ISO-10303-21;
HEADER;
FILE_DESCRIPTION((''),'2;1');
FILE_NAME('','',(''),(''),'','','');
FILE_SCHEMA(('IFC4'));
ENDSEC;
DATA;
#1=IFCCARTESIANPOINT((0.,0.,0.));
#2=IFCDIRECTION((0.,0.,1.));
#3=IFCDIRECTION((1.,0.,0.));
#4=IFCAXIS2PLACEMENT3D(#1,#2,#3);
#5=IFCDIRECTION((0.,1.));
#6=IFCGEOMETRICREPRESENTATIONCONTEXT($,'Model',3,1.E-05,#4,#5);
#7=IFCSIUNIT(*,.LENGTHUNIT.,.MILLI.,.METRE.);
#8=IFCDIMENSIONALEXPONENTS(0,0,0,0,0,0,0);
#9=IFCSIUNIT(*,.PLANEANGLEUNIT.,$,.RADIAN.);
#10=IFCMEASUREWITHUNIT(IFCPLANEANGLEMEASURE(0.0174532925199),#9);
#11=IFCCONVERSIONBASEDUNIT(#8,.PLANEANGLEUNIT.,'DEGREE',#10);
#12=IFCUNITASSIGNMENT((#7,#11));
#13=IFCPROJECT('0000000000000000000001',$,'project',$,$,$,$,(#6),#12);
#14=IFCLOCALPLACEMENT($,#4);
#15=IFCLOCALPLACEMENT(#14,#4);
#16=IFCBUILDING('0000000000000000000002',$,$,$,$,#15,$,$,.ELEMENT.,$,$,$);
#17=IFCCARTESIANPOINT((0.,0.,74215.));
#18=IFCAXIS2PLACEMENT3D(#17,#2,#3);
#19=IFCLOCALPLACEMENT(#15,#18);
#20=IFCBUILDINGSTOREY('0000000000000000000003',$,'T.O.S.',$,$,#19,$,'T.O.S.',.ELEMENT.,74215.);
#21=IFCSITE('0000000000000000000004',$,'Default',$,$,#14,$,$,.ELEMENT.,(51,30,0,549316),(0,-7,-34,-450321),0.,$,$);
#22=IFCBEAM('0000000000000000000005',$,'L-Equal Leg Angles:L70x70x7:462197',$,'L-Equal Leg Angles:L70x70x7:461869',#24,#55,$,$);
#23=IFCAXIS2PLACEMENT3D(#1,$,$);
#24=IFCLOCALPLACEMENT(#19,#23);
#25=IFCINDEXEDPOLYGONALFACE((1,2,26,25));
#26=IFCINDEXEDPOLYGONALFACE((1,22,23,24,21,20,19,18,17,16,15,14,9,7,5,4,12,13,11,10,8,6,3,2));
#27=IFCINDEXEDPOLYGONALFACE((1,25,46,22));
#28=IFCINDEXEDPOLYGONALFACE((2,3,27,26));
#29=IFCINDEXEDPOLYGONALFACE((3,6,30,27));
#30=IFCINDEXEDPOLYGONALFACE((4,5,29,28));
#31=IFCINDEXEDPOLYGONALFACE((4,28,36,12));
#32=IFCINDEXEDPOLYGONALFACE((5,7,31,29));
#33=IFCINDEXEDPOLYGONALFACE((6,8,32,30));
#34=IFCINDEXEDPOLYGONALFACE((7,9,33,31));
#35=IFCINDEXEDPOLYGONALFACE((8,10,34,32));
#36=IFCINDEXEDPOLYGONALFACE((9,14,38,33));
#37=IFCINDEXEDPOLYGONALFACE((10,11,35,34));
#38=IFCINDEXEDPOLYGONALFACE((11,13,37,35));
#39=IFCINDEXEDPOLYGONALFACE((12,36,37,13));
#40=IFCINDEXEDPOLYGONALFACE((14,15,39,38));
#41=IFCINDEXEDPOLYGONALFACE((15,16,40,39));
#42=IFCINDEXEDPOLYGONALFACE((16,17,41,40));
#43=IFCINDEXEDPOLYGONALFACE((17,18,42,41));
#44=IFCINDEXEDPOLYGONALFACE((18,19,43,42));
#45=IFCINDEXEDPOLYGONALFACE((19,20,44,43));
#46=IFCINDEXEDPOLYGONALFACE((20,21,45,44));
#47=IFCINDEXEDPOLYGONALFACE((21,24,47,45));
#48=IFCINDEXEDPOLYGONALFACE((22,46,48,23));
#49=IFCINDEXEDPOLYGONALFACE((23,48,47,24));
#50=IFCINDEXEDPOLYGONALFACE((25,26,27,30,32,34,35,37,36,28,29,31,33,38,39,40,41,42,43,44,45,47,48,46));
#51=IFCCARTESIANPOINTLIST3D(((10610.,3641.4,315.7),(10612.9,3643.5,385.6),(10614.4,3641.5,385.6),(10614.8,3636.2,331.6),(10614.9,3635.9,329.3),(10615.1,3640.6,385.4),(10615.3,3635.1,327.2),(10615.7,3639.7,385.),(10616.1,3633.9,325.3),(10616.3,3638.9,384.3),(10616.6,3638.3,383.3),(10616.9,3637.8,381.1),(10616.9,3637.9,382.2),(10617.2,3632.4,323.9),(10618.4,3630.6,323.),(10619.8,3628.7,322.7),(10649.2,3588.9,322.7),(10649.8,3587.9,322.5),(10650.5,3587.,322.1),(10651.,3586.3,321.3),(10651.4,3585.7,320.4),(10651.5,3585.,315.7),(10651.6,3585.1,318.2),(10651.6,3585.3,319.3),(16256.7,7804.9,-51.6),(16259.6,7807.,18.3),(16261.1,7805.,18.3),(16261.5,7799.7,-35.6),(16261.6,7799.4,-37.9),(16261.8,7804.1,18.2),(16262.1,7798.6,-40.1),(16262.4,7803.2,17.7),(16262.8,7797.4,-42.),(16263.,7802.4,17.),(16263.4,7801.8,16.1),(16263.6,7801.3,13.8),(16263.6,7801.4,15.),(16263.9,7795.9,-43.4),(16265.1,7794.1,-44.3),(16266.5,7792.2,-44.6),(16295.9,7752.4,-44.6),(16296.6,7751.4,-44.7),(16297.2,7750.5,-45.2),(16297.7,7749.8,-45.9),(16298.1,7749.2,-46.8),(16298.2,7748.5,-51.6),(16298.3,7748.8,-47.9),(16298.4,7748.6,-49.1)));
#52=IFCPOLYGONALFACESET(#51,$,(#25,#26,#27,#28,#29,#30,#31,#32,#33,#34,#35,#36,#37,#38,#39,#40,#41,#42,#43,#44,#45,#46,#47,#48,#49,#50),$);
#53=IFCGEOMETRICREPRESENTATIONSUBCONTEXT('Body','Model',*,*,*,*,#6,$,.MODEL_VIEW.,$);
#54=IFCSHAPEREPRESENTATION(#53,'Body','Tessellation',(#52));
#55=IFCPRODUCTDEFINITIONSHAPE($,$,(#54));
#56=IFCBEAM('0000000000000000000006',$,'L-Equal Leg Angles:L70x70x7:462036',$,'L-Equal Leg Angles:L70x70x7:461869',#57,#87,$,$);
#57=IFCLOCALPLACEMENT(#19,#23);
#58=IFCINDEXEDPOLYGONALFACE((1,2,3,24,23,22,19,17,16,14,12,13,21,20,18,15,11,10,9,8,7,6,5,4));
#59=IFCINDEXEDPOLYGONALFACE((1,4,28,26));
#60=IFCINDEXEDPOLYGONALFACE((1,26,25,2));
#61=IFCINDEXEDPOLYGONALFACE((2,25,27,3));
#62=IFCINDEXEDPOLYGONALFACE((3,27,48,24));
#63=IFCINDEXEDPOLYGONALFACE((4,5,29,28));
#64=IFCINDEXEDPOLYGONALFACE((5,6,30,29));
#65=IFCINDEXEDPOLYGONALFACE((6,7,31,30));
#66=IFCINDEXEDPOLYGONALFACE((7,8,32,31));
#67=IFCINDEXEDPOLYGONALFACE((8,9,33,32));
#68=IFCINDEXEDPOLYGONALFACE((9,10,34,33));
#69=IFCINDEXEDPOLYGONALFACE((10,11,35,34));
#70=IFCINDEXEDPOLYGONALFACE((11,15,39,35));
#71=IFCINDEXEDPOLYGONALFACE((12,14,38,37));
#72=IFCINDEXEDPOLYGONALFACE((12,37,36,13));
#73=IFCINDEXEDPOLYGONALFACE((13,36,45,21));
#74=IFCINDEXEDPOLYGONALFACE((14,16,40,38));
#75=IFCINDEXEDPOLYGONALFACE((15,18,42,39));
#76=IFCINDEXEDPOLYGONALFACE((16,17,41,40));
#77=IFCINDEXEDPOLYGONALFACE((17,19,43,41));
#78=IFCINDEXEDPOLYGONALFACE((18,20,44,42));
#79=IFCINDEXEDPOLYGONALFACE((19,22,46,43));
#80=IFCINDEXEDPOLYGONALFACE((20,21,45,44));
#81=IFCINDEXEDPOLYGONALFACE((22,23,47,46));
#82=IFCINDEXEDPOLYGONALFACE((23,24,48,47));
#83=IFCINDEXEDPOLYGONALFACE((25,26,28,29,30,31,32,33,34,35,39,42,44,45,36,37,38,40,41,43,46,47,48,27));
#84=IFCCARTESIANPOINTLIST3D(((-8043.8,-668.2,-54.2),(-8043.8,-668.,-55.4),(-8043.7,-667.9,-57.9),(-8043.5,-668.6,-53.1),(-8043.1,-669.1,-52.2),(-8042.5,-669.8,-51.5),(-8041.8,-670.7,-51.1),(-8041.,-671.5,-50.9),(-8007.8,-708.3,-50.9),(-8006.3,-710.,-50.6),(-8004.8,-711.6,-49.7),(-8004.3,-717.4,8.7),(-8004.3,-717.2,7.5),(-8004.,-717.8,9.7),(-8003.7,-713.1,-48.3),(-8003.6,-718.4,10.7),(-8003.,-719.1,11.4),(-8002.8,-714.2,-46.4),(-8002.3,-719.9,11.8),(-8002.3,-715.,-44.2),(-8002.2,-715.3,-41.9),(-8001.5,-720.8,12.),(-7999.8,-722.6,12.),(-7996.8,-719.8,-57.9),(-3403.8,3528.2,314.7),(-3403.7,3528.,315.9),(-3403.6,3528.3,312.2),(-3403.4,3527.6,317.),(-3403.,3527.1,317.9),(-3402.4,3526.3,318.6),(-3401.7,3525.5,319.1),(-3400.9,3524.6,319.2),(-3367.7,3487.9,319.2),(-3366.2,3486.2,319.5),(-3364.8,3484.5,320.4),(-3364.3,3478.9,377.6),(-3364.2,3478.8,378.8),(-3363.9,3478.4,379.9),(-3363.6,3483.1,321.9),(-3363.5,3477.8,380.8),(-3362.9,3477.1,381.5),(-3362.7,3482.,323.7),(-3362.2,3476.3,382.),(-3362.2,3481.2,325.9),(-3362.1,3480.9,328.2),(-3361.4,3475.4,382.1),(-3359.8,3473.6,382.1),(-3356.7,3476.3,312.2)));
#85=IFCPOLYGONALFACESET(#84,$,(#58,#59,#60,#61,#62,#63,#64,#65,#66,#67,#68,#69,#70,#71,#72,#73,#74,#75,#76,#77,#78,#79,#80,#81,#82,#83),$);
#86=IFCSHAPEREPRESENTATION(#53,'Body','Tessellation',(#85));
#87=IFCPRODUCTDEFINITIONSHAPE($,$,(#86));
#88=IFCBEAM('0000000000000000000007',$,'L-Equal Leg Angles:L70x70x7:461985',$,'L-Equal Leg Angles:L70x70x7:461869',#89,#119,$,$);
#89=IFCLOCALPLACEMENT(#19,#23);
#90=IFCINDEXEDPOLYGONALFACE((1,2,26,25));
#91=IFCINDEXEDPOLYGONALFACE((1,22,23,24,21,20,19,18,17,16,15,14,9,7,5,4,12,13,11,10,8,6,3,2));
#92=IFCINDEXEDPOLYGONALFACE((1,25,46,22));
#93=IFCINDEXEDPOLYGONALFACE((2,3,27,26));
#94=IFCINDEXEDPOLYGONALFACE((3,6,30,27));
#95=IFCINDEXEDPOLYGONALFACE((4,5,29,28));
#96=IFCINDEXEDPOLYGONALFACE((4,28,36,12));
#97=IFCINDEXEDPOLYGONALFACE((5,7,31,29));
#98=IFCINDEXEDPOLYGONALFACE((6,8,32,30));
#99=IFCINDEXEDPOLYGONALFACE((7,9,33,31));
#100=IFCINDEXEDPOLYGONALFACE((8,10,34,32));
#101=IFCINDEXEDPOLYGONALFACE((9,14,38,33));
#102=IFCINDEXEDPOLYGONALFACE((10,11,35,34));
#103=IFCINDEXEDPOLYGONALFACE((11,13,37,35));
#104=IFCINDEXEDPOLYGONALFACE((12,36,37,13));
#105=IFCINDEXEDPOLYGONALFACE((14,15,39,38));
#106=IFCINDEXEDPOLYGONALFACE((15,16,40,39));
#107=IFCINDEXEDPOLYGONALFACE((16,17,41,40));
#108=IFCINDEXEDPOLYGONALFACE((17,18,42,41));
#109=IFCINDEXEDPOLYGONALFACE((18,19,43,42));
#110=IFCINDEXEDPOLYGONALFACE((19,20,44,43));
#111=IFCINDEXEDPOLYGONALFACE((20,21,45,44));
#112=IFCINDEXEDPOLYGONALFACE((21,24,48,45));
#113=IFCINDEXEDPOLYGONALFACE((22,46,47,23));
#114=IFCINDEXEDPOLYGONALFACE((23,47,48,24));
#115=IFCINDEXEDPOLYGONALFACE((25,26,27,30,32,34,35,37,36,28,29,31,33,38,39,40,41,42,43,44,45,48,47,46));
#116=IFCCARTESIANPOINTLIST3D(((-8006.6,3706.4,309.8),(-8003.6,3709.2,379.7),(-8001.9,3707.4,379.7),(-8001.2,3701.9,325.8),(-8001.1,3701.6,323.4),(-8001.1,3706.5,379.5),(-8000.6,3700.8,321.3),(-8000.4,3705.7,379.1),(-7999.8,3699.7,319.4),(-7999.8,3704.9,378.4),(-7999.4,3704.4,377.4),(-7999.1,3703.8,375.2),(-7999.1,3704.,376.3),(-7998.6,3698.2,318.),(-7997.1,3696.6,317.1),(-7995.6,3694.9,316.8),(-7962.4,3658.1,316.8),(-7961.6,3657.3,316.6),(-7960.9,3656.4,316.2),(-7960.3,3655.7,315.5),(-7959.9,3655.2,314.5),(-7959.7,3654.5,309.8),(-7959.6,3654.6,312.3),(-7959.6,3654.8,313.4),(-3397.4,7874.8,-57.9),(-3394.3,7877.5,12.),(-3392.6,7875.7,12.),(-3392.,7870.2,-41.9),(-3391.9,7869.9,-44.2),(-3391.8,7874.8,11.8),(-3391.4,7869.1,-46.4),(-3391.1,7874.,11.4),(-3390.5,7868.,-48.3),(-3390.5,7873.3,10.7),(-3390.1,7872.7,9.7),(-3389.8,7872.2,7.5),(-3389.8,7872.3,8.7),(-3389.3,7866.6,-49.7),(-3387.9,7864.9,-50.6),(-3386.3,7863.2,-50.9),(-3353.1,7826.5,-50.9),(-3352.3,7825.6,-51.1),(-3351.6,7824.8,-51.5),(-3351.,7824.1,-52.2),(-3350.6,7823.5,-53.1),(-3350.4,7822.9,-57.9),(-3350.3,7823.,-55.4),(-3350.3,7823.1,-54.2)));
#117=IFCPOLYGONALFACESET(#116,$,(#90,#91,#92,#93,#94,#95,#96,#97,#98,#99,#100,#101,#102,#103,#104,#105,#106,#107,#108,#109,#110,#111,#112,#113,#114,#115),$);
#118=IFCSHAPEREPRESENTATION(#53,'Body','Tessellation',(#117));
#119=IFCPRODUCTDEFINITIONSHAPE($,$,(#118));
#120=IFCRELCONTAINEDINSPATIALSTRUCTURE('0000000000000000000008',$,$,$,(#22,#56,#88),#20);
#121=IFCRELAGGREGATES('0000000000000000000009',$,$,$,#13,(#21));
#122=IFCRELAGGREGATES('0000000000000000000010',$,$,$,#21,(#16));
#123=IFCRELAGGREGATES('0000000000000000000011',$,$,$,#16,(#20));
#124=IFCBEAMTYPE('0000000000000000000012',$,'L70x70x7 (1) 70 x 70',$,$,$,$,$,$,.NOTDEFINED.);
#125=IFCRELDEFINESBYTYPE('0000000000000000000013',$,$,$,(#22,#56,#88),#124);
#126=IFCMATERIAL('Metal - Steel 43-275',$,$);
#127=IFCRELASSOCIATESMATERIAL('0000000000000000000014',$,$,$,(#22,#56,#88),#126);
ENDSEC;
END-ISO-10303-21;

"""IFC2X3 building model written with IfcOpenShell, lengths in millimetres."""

from ifc_helpers import new_model, entity, si_unit, converted_unit, point, direction, frame, frame_2d, origin_with_axes, place, context, subcontext, project, spatial, polyline, circle_curve, parameter, trimmed, segment, composite_curve, outline, extrude, clip, halfspace, material, type_object, element, save


model = new_model("IFC2X3")

# Units and contexts
model_context = context("Model", 3, precision=1e-05, world=origin_with_axes(), true_north=direction((0.0, 1.0)))
body_context = subcontext(model_context, "Body", "Model", "MODEL_VIEW")
ifc_project = project(units=[si_unit("LENGTHUNIT", "METRE", prefix="MILLI"), converted_unit("PLANEANGLEUNIT", "DEGREE", entity("IfcPlaneAngleMeasure", 0.0174532925199), si_unit("PLANEANGLEUNIT", "RADIAN"), dimensions=[0, 0, 0, 0, 0, 0, 0])], contexts=[model_context])

# Site, building, storey
site_placement = place(None, origin_with_axes())
site = spatial("IfcSite", under=ifc_project, at=site_placement, Name="Default", CompositionType="ELEMENT", RefLatitude=(51, 30, 0, 549316), RefLongitude=(0, -7, -34, -450321), RefElevation=0.0)
building_placement = place(site_placement, origin_with_axes())
building = spatial("IfcBuilding", under=site, at=building_placement, CompositionType="ELEMENT")
storey_placement = place(building_placement, frame((0.0, 0.0, 74215.0), z_axis=(0.0, 0.0, 1.0), x_axis=(1.0, 0.0, 0.0)))
storey = spatial("IfcBuildingStorey", under=building, at=storey_placement, Name="T.O.S.", LongName="T.O.S.", CompositionType="ELEMENT", Elevation=74215.0)

# Beams
ifc_material = material(Name="Metal - Steel 43-275")
beam_type_1 = type_object("IfcBeamType", Name="L70x70x7 (1) 70 x 70", PredefinedType="NOTDEFINED")
beam_1_placement = place(storey_placement, frame((10622.6, 3617.8, 342.3), z_axis=(0.0, 0.0, 1.0), x_axis=(0.593453, -0.804869, 0.0)))
element("IfcBeam", 1, at=beam_1_placement, inside=storey, type_object=beam_type_1, material=ifc_material, Name="L-Equal Leg Angles:L70x70x7:462197", ObjectType="L-Equal Leg Angles:L70x70x7:461869", context=body_context, shape_type="Clipping", body=[
    clip(clip(clip(clip(extrude(outline(composite_curve([segment(polyline([(-43.6, -26.4), (26.4, -26.4), (26.4, 43.6), (23.9, 43.6)]), True, "CONTINUOUS"), segment(trimmed(circle_curve(frame_2d((23.9, 39.1), x_axis=(0.0, 1.0)), 4.5), [point((23.9, 43.6)), parameter(0.0)], [point((19.4, 39.1)), parameter(90.0)], True, "CARTESIAN"), True, "CONTINUOUS"), segment(polyline([(19.4, 39.1), (19.4, -10.4)]), True, "CONTINUOUS"), segment(trimmed(circle_curve(frame_2d((10.4, -10.4), x_axis=(0.0, -1.0)), 9.0), [point((19.4, -10.4)), parameter(90.0)], [point((10.4, -19.4)), parameter(0.0)], False, "CARTESIAN"), True, "CONTINUOUS"), segment(polyline([(10.4, -19.4), (-39.1, -19.4)]), True, "CONTINUOUS"), segment(trimmed(circle_curve(frame_2d((-39.1, -23.9), x_axis=(0.0, 1.0)), 4.5), [point((-39.1, -19.4)), parameter(0.0)], [point((-43.6, -23.9)), parameter(90.0)], True, "CARTESIAN"), True, "CONTINUOUS"), segment(polyline([(-43.6, -23.9), (-43.6, -26.4)]), True, "CONTINUOUS")], self_intersect=False)), frame((0.0, 7031.2, -368.1), z_axis=(0.0, -0.998633, 0.052275), x_axis=(0.0, -0.052275, -0.998633)), (0.0, 0.0, 1.0), 7046.0), halfspace(frame((0.0, 7020.9, -367.5), z_axis=(0.0, -0.998633, 0.052275), x_axis=(0.0, -0.052275, -0.998633)), True)), halfspace(frame((0.0, 5.2, -0.3), z_axis=(0.0, 0.998633, -0.052275), x_axis=(0.0, 0.052275, 0.998633)), True)), halfspace(frame((0.0, 7026.0, 0.0), z_axis=(0.0, -1.0, 0.0), x_axis=(0.0, 0.0, -1.0)), True)), halfspace(frame((0.0, 0.0, 0.0), z_axis=(0.0, 1.0, 0.0), x_axis=(0.0, 0.0, 1.0)), True)),
])
beam_2_placement = place(storey_placement, frame((-3371.3, 3498.8, 339.0), z_axis=(0.0, 0.0, 1.0), x_axis=(-0.670739, 0.741693, 0.0)))
element("IfcBeam", 2, at=beam_2_placement, inside=storey, type_object=beam_type_1, material=ifc_material, Name="L-Equal Leg Angles:L70x70x7:462036", ObjectType="L-Equal Leg Angles:L70x70x7:461869", context=body_context, shape_type="Clipping", body=[
    clip(clip(clip(clip(extrude(outline(composite_curve([segment(polyline([(-43.6, -26.4), (26.4, -26.4), (26.4, 43.6), (23.9, 43.6)]), True, "CONTINUOUS"), segment(trimmed(circle_curve(frame_2d((23.9, 39.1), x_axis=(0.0, 1.0)), 4.5), [point((23.9, 43.6)), parameter(0.0)], [point((19.4, 39.1)), parameter(90.0)], True, "CARTESIAN"), True, "CONTINUOUS"), segment(polyline([(19.4, 39.1), (19.4, -10.4)]), True, "CONTINUOUS"), segment(trimmed(circle_curve(frame_2d((10.4, -10.4), x_axis=(0.0, -1.0)), 9.0), [point((19.4, -10.4)), parameter(90.0)], [point((10.4, -19.4)), parameter(0.0)], False, "CARTESIAN"), True, "CONTINUOUS"), segment(polyline([(10.4, -19.4), (-39.1, -19.4)]), True, "CONTINUOUS"), segment(trimmed(circle_curve(frame_2d((-39.1, -23.9), x_axis=(0.0, 1.0)), 4.5), [point((-39.1, -19.4)), parameter(0.0)], [point((-43.6, -23.9)), parameter(90.0)], True, "CARTESIAN"), True, "CONTINUOUS"), segment(polyline([(-43.6, -23.9), (-43.6, -26.4)]), True, "CONTINUOUS")], self_intersect=False)), frame((0.0, 6273.6, -371.2), z_axis=(0.0, -0.998254, 0.059061), x_axis=(0.0, -0.059061, -0.998254)), (0.0, 0.0, 1.0), 6290.4), halfspace(frame((0.0, 6261.9, -370.5), z_axis=(0.0, -0.998254, 0.059061), x_axis=(0.0, -0.059061, -0.998254)), True)), halfspace(frame((0.0, 5.8, -0.3), z_axis=(0.0, 0.998254, -0.059061), x_axis=(0.0, 0.059061, 0.998254)), True)), halfspace(frame((0.0, 6267.8, 0.0), z_axis=(0.0, -1.0, 0.0), x_axis=(0.0, 0.0, -1.0)), True)), halfspace(frame((0.0, 0.0, 0.0), z_axis=(0.0, 1.0, 0.0), x_axis=(0.0, 0.0, 1.0)), True)),
])
beam_3_placement = place(storey_placement, frame((-7992.1, 3684.0, 336.5), z_axis=(0.0, 0.0, 1.0), x_axis=(0.670739, -0.741693, 0.0)))
element("IfcBeam", 3, at=beam_3_placement, inside=storey, type_object=beam_type_1, material=ifc_material, Name="L-Equal Leg Angles:L70x70x7:461985", ObjectType="L-Equal Leg Angles:L70x70x7:461869", context=body_context, shape_type="Clipping", body=[
    clip(clip(clip(clip(extrude(outline(composite_curve([segment(polyline([(-43.6, -26.4), (26.4, -26.4), (26.4, 43.6), (23.9, 43.6)]), True, "CONTINUOUS"), segment(trimmed(circle_curve(frame_2d((23.9, 39.1), x_axis=(0.0, 1.0)), 4.5), [point((23.9, 43.6)), parameter(0.0)], [point((19.4, 39.1)), parameter(90.0)], True, "CARTESIAN"), True, "CONTINUOUS"), segment(polyline([(19.4, 39.1), (19.4, -10.4)]), True, "CONTINUOUS"), segment(trimmed(circle_curve(frame_2d((10.4, -10.4), x_axis=(0.0, -1.0)), 9.0), [point((19.4, -10.4)), parameter(90.0)], [point((10.4, -19.4)), parameter(0.0)], False, "CARTESIAN"), True, "CONTINUOUS"), segment(polyline([(10.4, -19.4), (-39.1, -19.4)]), True, "CONTINUOUS"), segment(trimmed(circle_curve(frame_2d((-39.1, -23.9), x_axis=(0.0, 1.0)), 4.5), [point((-39.1, -19.4)), parameter(0.0)], [point((-43.6, -23.9)), parameter(90.0)], True, "CARTESIAN"), True, "CONTINUOUS"), segment(polyline([(-43.6, -23.9), (-43.6, -26.4)]), True, "CONTINUOUS")], self_intersect=False)), frame((0.0, 6232.1, -368.7), z_axis=(0.0, -0.998254, 0.059061), x_axis=(0.0, -0.059061, -0.998254)), (0.0, 0.0, 1.0), 6248.8), halfspace(frame((0.0, 6220.4, -368.0), z_axis=(0.0, -0.998254, 0.059061), x_axis=(0.0, -0.059061, -0.998254)), True)), halfspace(frame((0.0, 5.8, -0.3), z_axis=(0.0, 0.998254, -0.059061), x_axis=(0.0, 0.059061, 0.998254)), True)), halfspace(frame((0.0, 6226.2, 0.0), z_axis=(0.0, -1.0, 0.0), x_axis=(0.0, 0.0, -1.0)), True)), halfspace(frame((0.0, 0.0, 0.0), z_axis=(0.0, 1.0, 0.0), x_axis=(0.0, 0.0, 1.0)), True)),
])

save(model, "model.ifc")
